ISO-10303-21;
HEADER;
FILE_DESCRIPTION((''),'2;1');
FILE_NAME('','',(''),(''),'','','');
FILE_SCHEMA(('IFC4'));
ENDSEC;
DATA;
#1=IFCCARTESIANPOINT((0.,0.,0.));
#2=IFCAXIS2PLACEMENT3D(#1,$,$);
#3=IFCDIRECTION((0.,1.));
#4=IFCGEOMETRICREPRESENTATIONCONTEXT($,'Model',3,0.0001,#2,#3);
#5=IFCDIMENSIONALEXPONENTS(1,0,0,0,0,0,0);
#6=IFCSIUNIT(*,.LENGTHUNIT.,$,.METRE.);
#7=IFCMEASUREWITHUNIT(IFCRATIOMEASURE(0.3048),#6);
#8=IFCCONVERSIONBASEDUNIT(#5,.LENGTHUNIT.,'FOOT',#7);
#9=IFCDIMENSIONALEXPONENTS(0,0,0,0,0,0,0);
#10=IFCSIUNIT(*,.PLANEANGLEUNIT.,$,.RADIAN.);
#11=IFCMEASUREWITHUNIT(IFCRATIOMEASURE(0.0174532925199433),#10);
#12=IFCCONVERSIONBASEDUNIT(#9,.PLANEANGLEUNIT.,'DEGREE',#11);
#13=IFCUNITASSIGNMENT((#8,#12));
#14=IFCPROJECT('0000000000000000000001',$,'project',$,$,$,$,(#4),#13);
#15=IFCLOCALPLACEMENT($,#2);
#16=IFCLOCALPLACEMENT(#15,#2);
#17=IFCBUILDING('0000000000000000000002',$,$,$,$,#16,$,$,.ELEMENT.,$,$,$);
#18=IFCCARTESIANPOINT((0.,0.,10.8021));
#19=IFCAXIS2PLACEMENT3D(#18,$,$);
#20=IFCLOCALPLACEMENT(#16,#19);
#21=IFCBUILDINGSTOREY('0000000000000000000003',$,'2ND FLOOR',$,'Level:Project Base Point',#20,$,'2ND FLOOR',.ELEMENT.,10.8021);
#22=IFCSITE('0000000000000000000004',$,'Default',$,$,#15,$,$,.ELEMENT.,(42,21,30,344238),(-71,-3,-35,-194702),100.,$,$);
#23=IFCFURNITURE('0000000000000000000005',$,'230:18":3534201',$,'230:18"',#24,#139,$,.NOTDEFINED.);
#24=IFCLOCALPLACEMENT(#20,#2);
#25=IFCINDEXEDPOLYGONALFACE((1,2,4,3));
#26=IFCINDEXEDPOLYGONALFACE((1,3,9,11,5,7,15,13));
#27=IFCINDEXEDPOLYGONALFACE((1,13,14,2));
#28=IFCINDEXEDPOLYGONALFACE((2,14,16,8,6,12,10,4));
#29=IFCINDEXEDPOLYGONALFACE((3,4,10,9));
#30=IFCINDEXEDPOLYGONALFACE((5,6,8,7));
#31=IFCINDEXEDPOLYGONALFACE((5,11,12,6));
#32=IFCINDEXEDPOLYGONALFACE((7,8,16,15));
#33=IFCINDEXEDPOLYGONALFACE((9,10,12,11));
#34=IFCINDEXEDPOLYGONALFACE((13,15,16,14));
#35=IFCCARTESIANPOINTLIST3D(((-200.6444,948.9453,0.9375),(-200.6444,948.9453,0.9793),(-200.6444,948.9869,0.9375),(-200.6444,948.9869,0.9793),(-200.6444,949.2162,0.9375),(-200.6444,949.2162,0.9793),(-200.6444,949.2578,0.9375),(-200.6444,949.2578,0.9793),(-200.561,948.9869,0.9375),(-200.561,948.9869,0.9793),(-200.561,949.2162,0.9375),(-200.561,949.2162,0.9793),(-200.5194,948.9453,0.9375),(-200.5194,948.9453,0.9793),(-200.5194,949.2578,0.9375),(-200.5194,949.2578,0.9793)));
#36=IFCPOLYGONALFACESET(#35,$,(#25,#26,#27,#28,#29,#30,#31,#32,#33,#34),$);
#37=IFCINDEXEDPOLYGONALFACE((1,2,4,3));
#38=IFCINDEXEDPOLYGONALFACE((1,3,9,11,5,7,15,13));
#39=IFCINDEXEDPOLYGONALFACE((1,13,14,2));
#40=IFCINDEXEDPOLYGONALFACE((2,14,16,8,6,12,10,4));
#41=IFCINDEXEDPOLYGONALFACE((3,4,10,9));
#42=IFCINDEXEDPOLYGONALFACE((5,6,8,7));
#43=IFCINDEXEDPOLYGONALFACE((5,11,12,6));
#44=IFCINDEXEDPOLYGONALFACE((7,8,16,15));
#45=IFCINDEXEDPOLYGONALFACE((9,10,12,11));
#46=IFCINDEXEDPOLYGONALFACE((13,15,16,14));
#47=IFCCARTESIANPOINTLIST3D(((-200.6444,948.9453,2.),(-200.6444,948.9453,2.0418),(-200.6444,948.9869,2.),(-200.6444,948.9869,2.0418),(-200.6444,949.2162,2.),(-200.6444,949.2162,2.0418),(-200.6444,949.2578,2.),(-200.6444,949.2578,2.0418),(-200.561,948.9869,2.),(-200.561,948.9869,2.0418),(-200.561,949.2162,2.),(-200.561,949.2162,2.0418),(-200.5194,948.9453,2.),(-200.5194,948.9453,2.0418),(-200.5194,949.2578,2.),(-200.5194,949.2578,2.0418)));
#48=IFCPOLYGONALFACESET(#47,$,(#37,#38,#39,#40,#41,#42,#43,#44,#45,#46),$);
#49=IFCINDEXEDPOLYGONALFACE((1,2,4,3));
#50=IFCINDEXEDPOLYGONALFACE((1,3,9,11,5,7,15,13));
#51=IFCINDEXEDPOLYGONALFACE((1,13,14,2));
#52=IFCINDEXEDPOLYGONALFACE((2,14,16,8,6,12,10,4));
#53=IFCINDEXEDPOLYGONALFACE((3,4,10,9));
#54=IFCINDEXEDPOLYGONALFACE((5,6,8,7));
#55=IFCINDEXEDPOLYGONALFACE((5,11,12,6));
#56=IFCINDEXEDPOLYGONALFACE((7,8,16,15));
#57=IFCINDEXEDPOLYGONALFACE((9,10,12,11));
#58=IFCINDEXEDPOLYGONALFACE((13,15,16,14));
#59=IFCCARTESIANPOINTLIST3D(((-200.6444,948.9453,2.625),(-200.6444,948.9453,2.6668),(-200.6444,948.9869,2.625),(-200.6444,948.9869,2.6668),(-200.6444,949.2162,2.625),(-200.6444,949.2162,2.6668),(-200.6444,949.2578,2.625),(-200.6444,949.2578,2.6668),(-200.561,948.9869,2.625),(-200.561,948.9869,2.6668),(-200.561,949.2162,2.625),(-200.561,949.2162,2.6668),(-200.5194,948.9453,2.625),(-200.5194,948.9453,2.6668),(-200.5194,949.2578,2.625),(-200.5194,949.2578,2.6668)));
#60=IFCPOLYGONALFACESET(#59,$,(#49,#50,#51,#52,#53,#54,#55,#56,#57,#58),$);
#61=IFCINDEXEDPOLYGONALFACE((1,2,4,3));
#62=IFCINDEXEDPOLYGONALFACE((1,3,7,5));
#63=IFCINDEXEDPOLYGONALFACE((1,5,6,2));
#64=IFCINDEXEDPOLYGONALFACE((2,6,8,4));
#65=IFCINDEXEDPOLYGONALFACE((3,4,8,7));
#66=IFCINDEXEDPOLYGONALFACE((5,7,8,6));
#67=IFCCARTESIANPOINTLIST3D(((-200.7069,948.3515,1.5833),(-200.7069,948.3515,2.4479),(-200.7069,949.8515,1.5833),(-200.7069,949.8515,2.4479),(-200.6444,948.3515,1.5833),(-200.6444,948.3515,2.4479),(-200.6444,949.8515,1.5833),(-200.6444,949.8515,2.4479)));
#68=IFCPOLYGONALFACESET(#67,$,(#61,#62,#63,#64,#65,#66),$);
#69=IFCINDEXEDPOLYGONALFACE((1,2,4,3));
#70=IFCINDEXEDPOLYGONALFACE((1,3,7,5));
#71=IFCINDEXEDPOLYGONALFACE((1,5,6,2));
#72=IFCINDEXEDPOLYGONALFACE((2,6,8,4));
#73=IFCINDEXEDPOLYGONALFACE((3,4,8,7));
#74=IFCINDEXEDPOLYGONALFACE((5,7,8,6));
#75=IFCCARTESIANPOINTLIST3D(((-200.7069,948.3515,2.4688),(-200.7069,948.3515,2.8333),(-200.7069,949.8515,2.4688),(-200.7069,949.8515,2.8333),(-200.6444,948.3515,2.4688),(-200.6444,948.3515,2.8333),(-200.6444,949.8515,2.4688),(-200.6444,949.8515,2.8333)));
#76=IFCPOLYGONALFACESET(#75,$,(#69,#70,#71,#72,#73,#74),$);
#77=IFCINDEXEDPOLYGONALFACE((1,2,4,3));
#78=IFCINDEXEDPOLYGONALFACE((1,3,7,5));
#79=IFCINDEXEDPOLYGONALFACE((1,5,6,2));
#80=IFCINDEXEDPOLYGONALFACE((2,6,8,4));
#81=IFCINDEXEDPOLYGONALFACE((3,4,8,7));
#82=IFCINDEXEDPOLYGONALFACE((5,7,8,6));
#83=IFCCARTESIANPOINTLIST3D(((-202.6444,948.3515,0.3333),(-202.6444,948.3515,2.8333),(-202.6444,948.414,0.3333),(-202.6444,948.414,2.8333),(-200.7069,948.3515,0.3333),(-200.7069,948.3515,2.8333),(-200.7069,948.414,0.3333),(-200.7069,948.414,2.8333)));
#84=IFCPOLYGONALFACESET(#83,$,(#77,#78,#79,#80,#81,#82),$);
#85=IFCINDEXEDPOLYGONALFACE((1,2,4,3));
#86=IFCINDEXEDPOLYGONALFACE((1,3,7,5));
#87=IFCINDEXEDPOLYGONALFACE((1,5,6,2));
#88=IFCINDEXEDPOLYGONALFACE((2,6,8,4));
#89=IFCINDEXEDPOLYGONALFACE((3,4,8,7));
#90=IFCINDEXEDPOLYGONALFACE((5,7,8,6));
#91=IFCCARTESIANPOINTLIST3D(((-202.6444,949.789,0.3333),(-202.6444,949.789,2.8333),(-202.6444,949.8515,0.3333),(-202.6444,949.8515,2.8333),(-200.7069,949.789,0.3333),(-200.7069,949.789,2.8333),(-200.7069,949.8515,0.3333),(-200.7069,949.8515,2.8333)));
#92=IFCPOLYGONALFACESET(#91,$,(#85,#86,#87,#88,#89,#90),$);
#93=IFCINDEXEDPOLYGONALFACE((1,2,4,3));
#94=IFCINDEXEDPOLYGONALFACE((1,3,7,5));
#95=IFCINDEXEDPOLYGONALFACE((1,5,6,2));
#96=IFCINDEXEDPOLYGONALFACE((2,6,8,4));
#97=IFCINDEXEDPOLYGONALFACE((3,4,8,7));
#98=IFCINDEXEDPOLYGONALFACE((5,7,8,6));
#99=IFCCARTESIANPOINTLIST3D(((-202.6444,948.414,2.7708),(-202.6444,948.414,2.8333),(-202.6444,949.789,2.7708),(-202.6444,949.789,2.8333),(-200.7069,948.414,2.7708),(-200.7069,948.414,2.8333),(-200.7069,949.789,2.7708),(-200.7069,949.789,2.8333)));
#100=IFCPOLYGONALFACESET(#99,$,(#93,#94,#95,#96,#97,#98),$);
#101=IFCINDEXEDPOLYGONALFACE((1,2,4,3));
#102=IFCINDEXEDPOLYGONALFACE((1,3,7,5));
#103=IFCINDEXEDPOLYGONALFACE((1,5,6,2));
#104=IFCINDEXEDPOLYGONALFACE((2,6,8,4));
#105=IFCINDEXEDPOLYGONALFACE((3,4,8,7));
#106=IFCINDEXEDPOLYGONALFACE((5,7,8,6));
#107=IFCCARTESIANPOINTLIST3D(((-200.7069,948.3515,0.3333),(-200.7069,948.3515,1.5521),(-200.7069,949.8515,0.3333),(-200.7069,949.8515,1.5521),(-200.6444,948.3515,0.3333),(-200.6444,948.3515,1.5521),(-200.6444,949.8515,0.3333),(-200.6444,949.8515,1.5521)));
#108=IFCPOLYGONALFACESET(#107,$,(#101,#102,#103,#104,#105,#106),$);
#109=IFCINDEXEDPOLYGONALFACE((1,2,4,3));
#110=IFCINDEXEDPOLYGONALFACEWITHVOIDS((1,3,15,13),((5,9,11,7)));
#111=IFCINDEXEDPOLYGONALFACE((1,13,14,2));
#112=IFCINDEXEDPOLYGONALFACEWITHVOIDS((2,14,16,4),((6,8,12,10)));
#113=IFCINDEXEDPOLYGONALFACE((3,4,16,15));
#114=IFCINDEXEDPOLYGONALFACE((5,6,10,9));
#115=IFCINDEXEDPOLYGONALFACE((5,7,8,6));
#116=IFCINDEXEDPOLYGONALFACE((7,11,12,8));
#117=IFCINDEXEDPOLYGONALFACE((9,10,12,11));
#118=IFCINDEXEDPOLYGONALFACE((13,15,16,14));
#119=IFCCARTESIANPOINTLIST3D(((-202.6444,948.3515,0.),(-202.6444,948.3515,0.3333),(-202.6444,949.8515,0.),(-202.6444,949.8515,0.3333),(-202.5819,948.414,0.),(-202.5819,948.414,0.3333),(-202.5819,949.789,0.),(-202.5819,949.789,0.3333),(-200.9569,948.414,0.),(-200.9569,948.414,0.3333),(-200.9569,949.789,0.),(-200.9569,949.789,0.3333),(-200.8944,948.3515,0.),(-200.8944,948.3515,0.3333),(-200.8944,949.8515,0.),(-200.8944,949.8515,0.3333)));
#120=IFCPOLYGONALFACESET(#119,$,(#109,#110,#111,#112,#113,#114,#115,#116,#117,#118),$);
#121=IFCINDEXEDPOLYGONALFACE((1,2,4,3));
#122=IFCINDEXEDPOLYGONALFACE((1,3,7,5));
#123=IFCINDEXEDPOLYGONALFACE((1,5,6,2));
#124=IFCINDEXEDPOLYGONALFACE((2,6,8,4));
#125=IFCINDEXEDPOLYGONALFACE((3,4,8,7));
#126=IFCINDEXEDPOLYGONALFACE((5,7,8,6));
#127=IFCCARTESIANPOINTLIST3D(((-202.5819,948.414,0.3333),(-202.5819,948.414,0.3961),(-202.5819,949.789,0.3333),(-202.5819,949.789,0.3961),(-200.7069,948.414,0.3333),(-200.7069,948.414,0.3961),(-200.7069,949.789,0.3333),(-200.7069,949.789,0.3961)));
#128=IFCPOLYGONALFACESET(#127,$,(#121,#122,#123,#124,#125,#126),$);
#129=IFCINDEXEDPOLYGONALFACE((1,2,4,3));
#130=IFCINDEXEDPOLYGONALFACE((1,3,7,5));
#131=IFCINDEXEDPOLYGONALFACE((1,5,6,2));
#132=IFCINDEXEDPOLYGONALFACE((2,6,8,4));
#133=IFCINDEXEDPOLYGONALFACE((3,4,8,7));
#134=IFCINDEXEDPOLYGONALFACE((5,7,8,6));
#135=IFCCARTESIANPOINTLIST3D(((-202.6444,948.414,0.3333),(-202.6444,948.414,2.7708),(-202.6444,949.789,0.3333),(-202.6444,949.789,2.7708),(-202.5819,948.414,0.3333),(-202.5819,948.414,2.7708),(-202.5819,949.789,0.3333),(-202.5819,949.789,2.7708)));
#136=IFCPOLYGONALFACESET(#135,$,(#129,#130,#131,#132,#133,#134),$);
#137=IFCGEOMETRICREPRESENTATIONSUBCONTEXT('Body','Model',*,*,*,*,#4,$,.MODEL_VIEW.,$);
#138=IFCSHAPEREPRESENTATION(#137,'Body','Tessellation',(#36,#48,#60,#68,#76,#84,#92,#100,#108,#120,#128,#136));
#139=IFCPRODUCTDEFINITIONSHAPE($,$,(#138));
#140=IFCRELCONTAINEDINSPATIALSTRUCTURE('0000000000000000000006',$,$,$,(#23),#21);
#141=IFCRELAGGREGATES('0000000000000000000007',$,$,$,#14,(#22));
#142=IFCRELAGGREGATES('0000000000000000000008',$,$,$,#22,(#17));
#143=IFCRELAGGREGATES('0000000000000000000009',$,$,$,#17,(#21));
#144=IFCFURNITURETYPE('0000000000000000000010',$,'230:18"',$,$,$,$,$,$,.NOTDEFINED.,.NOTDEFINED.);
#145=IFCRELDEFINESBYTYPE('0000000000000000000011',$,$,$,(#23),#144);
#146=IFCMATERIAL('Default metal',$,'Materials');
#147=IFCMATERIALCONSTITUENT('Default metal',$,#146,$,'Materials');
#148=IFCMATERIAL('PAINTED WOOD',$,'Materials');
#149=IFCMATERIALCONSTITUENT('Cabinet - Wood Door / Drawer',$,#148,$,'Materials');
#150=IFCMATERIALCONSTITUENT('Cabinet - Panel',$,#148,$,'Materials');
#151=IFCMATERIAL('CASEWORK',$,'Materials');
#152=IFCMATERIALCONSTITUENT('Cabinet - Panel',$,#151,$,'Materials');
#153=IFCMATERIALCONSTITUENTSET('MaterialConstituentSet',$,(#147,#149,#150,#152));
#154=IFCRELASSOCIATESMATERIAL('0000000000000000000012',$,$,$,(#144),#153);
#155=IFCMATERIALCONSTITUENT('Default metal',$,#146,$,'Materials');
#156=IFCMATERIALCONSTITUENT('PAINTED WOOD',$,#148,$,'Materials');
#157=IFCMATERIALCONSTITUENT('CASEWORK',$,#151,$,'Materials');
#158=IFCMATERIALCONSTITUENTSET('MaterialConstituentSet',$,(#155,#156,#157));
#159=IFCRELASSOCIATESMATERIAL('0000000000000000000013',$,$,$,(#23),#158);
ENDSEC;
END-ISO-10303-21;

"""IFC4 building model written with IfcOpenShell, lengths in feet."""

from ifc_helpers import new_model, entity, si_unit, converted_unit, direction, frame, frame_2d, origin, origin_2d_with_axis, place, context, subcontext, project, spatial, polyline, rectangle, outline, extrude, source, transform, mapped, material, constituent, constituent_set, type_object, type_shapes, element, save


model = new_model("IFC4")

# Units and contexts
model_context = context("Model", 3, precision=0.0001, world=origin(), true_north=direction((0.0, 1.0)))
body_context = subcontext(model_context, "Body", "Model", "MODEL_VIEW")
ifc_project = project(units=[converted_unit("LENGTHUNIT", "FOOT", entity("IfcRatioMeasure", 0.3048), si_unit("LENGTHUNIT", "METRE"), dimensions=[1, 0, 0, 0, 0, 0, 0]), converted_unit("PLANEANGLEUNIT", "DEGREE", entity("IfcRatioMeasure", 0.0174532925199433), si_unit("PLANEANGLEUNIT", "RADIAN"), dimensions=[0, 0, 0, 0, 0, 0, 0])], contexts=[model_context])

# Site, building, storey
site_placement = place(None, origin())
site = spatial("IfcSite", under=ifc_project, at=site_placement, Name="Default", CompositionType="ELEMENT", RefLatitude=(42, 21, 30, 344238), RefLongitude=(-71, -3, -35, -194702), RefElevation=100.0)
building_placement = place(site_placement, origin())
building = spatial("IfcBuilding", under=site, at=building_placement, CompositionType="ELEMENT")
storey_placement = place(building_placement, frame((0.0, 0.0, 10.8021)))
storey = spatial("IfcBuildingStorey", under=building, at=storey_placement, Name="2ND FLOOR", ObjectType="Level:Project Base Point", LongName="2ND FLOOR", CompositionType="ELEMENT", Elevation=10.8021)

# Furniture
ifc_material_1 = material(Name="CASEWORK", Category="Materials")
ifc_material_2 = material(Name="PAINTED WOOD", Category="Materials")
ifc_material_3 = material(Name="Default metal", Category="Materials")
ifc_constituent_1 = constituent(ifc_material_3, Name="Default metal", Category="Materials")
ifc_constituent_2 = constituent(ifc_material_2, Name="PAINTED WOOD", Category="Materials")
ifc_constituent_3 = constituent(ifc_material_1, Name="CASEWORK", Category="Materials")
ifc_constituent_set_1 = constituent_set(constituents=[ifc_constituent_1, ifc_constituent_2, ifc_constituent_3], Name="MaterialConstituentSet")
ifc_constituent_4 = constituent(ifc_material_3, Name="Default metal", Category="Materials")
ifc_constituent_5 = constituent(ifc_material_2, Name="Cabinet - Wood Door / Drawer", Category="Materials")
ifc_constituent_6 = constituent(ifc_material_2, Name="Cabinet - Panel", Category="Materials")
ifc_constituent_7 = constituent(ifc_material_1, Name="Cabinet - Panel", Category="Materials")
ifc_constituent_set_2 = constituent_set(constituents=[ifc_constituent_4, ifc_constituent_5, ifc_constituent_6, ifc_constituent_7], Name="MaterialConstituentSet")
furniture_type_1 = type_object("IfcFurnitureType", Name="230:18\"", AssemblyPlace="NOTDEFINED", PredefinedType="NOTDEFINED", material=ifc_constituent_set_2)
shared_shape_1 = source(origin(), body_context, "Body", "SweptSolid", [
    extrude(outline(polyline([(-0.0521, -0.1562), (0.0729, -0.1562), (0.0729, 0.1562), (-0.0521, 0.1562), (-0.0521, 0.1146), (0.0313, 0.1146), (0.0313, -0.1146), (-0.0521, -0.1146), (-0.0521, -0.1562)])), frame((0.0615, -2.0521, 0.9375), z_axis=(0.0, 0.0, 1.0), x_axis=(0.0, -1.0, 0.0)), (0.0, 0.0, 1.0), 0.0418),
    extrude(outline(polyline([(-0.0521, -0.1562), (0.0729, -0.1562), (0.0729, 0.1562), (-0.0521, 0.1562), (-0.0521, 0.1146), (0.0313, 0.1146), (0.0313, -0.1146), (-0.0521, -0.1146), (-0.0521, -0.1562)])), frame((0.0615, -2.0521, 2.0), z_axis=(0.0, 0.0, 1.0), x_axis=(0.0, -1.0, 0.0)), (0.0, 0.0, 1.0), 0.0418),
    extrude(outline(polyline([(-0.0521, -0.1562), (0.0729, -0.1562), (0.0729, 0.1562), (-0.0521, 0.1562), (-0.0521, 0.1146), (0.0313, 0.1146), (0.0313, -0.1146), (-0.0521, -0.1146), (-0.0521, -0.1562)])), frame((0.0615, -2.0521, 2.625), z_axis=(0.0, 0.0, 1.0), x_axis=(0.0, -1.0, 0.0)), (0.0, 0.0, 1.0), 0.0418),
    extrude(rectangle(XDim=0.0625, YDim=1.5, at=frame_2d((0.0, 0.0), x_axis=(1.0, 0.0))), frame((0.0615, -1.9688, 1.5833), z_axis=(0.0, 0.0, 1.0), x_axis=(0.0, 1.0, 0.0)), (0.0, 0.0, 1.0), 0.8646),
    extrude(rectangle(XDim=0.0625, YDim=1.5, at=frame_2d((0.0, 0.0), x_axis=(1.0, 0.0))), frame((0.0615, -1.9688, 2.4688), z_axis=(0.0, 0.0, 1.0), x_axis=(0.0, 1.0, 0.0)), (0.0, 0.0, 1.0), 0.3646),
    extrude(rectangle(XDim=0.0625, YDim=1.9375, at=frame_2d((0.0, 0.0), x_axis=(1.0, 0.0))), frame((-0.6573, -0.9687, 0.3333)), (0.0, 0.0, 1.0), 2.5),
    extrude(rectangle(XDim=0.0625, YDim=1.9375, at=frame_2d((0.0, 0.0), x_axis=(1.0, 0.0))), frame((0.7802, -0.9687, 0.3333)), (0.0, 0.0, 1.0), 2.5),
    extrude(rectangle(XDim=1.375, YDim=1.9375, at=origin_2d_with_axis()), frame((0.0615, -0.9687, 2.7708), z_axis=(0.0, 0.0, 1.0), x_axis=(-1.0, 0.0, 0.0)), (0.0, 0.0, 1.0), 0.0625),
    extrude(rectangle(XDim=0.0625, YDim=1.5, at=frame_2d((0.0, 0.0), x_axis=(1.0, 0.0))), frame((0.0615, -1.9688, 0.3333), z_axis=(0.0, 0.0, 1.0), x_axis=(0.0, 1.0, 0.0)), (0.0, 0.0, 1.0), 1.2187),
    extrude(outline(polyline([(-0.75, -0.875), (0.75, -0.875), (0.75, 0.875), (-0.75, 0.875), (-0.75, -0.875)]), holes=[polyline([(-0.6875, -0.8125), (-0.6875, 0.8125), (0.6875, 0.8125), (0.6875, -0.8125), (-0.6875, -0.8125)])]), frame((0.0615, -0.875, 0.0)), (0.0, 0.0, 1.0), 0.3333),
    extrude(rectangle(XDim=1.375, YDim=1.875, at=frame_2d((0.0, 0.0), x_axis=(1.0, 0.0))), frame((0.0615, -1.0, 0.3333), z_axis=(0.0, 0.0, 1.0), x_axis=(-1.0, 0.0, 0.0)), (0.0, 0.0, 1.0), 0.0627),
    extrude(rectangle(XDim=0.0625, YDim=1.375, at=origin_2d_with_axis()), frame((0.0615, -0.0312, 0.3333), z_axis=(0.0, 0.0, 1.0), x_axis=(0.0, 1.0, 0.0)), (0.0, 0.0, 1.0), 2.4375),
])
type_shapes(furniture_type_1, [shared_shape_1])
furniture_1_placement = place(storey_placement, frame((-202.6444, 949.04, 0.0), z_axis=(0.0, 0.0, 1.0), x_axis=(0.0, 1.0, 0.0)))
element("IfcFurniture", 1, at=furniture_1_placement, inside=storey, type_object=furniture_type_1, material=ifc_constituent_set_1, Name="230:18\":3534201", ObjectType="230:18\"", PredefinedType="NOTDEFINED", context=body_context, shape_type="MappedRepresentation", body=[
    mapped(shared_shape_1, transform((0.0, 0.0, 0.0), scale=1.0)),
])

save(model, "model.ifc")
